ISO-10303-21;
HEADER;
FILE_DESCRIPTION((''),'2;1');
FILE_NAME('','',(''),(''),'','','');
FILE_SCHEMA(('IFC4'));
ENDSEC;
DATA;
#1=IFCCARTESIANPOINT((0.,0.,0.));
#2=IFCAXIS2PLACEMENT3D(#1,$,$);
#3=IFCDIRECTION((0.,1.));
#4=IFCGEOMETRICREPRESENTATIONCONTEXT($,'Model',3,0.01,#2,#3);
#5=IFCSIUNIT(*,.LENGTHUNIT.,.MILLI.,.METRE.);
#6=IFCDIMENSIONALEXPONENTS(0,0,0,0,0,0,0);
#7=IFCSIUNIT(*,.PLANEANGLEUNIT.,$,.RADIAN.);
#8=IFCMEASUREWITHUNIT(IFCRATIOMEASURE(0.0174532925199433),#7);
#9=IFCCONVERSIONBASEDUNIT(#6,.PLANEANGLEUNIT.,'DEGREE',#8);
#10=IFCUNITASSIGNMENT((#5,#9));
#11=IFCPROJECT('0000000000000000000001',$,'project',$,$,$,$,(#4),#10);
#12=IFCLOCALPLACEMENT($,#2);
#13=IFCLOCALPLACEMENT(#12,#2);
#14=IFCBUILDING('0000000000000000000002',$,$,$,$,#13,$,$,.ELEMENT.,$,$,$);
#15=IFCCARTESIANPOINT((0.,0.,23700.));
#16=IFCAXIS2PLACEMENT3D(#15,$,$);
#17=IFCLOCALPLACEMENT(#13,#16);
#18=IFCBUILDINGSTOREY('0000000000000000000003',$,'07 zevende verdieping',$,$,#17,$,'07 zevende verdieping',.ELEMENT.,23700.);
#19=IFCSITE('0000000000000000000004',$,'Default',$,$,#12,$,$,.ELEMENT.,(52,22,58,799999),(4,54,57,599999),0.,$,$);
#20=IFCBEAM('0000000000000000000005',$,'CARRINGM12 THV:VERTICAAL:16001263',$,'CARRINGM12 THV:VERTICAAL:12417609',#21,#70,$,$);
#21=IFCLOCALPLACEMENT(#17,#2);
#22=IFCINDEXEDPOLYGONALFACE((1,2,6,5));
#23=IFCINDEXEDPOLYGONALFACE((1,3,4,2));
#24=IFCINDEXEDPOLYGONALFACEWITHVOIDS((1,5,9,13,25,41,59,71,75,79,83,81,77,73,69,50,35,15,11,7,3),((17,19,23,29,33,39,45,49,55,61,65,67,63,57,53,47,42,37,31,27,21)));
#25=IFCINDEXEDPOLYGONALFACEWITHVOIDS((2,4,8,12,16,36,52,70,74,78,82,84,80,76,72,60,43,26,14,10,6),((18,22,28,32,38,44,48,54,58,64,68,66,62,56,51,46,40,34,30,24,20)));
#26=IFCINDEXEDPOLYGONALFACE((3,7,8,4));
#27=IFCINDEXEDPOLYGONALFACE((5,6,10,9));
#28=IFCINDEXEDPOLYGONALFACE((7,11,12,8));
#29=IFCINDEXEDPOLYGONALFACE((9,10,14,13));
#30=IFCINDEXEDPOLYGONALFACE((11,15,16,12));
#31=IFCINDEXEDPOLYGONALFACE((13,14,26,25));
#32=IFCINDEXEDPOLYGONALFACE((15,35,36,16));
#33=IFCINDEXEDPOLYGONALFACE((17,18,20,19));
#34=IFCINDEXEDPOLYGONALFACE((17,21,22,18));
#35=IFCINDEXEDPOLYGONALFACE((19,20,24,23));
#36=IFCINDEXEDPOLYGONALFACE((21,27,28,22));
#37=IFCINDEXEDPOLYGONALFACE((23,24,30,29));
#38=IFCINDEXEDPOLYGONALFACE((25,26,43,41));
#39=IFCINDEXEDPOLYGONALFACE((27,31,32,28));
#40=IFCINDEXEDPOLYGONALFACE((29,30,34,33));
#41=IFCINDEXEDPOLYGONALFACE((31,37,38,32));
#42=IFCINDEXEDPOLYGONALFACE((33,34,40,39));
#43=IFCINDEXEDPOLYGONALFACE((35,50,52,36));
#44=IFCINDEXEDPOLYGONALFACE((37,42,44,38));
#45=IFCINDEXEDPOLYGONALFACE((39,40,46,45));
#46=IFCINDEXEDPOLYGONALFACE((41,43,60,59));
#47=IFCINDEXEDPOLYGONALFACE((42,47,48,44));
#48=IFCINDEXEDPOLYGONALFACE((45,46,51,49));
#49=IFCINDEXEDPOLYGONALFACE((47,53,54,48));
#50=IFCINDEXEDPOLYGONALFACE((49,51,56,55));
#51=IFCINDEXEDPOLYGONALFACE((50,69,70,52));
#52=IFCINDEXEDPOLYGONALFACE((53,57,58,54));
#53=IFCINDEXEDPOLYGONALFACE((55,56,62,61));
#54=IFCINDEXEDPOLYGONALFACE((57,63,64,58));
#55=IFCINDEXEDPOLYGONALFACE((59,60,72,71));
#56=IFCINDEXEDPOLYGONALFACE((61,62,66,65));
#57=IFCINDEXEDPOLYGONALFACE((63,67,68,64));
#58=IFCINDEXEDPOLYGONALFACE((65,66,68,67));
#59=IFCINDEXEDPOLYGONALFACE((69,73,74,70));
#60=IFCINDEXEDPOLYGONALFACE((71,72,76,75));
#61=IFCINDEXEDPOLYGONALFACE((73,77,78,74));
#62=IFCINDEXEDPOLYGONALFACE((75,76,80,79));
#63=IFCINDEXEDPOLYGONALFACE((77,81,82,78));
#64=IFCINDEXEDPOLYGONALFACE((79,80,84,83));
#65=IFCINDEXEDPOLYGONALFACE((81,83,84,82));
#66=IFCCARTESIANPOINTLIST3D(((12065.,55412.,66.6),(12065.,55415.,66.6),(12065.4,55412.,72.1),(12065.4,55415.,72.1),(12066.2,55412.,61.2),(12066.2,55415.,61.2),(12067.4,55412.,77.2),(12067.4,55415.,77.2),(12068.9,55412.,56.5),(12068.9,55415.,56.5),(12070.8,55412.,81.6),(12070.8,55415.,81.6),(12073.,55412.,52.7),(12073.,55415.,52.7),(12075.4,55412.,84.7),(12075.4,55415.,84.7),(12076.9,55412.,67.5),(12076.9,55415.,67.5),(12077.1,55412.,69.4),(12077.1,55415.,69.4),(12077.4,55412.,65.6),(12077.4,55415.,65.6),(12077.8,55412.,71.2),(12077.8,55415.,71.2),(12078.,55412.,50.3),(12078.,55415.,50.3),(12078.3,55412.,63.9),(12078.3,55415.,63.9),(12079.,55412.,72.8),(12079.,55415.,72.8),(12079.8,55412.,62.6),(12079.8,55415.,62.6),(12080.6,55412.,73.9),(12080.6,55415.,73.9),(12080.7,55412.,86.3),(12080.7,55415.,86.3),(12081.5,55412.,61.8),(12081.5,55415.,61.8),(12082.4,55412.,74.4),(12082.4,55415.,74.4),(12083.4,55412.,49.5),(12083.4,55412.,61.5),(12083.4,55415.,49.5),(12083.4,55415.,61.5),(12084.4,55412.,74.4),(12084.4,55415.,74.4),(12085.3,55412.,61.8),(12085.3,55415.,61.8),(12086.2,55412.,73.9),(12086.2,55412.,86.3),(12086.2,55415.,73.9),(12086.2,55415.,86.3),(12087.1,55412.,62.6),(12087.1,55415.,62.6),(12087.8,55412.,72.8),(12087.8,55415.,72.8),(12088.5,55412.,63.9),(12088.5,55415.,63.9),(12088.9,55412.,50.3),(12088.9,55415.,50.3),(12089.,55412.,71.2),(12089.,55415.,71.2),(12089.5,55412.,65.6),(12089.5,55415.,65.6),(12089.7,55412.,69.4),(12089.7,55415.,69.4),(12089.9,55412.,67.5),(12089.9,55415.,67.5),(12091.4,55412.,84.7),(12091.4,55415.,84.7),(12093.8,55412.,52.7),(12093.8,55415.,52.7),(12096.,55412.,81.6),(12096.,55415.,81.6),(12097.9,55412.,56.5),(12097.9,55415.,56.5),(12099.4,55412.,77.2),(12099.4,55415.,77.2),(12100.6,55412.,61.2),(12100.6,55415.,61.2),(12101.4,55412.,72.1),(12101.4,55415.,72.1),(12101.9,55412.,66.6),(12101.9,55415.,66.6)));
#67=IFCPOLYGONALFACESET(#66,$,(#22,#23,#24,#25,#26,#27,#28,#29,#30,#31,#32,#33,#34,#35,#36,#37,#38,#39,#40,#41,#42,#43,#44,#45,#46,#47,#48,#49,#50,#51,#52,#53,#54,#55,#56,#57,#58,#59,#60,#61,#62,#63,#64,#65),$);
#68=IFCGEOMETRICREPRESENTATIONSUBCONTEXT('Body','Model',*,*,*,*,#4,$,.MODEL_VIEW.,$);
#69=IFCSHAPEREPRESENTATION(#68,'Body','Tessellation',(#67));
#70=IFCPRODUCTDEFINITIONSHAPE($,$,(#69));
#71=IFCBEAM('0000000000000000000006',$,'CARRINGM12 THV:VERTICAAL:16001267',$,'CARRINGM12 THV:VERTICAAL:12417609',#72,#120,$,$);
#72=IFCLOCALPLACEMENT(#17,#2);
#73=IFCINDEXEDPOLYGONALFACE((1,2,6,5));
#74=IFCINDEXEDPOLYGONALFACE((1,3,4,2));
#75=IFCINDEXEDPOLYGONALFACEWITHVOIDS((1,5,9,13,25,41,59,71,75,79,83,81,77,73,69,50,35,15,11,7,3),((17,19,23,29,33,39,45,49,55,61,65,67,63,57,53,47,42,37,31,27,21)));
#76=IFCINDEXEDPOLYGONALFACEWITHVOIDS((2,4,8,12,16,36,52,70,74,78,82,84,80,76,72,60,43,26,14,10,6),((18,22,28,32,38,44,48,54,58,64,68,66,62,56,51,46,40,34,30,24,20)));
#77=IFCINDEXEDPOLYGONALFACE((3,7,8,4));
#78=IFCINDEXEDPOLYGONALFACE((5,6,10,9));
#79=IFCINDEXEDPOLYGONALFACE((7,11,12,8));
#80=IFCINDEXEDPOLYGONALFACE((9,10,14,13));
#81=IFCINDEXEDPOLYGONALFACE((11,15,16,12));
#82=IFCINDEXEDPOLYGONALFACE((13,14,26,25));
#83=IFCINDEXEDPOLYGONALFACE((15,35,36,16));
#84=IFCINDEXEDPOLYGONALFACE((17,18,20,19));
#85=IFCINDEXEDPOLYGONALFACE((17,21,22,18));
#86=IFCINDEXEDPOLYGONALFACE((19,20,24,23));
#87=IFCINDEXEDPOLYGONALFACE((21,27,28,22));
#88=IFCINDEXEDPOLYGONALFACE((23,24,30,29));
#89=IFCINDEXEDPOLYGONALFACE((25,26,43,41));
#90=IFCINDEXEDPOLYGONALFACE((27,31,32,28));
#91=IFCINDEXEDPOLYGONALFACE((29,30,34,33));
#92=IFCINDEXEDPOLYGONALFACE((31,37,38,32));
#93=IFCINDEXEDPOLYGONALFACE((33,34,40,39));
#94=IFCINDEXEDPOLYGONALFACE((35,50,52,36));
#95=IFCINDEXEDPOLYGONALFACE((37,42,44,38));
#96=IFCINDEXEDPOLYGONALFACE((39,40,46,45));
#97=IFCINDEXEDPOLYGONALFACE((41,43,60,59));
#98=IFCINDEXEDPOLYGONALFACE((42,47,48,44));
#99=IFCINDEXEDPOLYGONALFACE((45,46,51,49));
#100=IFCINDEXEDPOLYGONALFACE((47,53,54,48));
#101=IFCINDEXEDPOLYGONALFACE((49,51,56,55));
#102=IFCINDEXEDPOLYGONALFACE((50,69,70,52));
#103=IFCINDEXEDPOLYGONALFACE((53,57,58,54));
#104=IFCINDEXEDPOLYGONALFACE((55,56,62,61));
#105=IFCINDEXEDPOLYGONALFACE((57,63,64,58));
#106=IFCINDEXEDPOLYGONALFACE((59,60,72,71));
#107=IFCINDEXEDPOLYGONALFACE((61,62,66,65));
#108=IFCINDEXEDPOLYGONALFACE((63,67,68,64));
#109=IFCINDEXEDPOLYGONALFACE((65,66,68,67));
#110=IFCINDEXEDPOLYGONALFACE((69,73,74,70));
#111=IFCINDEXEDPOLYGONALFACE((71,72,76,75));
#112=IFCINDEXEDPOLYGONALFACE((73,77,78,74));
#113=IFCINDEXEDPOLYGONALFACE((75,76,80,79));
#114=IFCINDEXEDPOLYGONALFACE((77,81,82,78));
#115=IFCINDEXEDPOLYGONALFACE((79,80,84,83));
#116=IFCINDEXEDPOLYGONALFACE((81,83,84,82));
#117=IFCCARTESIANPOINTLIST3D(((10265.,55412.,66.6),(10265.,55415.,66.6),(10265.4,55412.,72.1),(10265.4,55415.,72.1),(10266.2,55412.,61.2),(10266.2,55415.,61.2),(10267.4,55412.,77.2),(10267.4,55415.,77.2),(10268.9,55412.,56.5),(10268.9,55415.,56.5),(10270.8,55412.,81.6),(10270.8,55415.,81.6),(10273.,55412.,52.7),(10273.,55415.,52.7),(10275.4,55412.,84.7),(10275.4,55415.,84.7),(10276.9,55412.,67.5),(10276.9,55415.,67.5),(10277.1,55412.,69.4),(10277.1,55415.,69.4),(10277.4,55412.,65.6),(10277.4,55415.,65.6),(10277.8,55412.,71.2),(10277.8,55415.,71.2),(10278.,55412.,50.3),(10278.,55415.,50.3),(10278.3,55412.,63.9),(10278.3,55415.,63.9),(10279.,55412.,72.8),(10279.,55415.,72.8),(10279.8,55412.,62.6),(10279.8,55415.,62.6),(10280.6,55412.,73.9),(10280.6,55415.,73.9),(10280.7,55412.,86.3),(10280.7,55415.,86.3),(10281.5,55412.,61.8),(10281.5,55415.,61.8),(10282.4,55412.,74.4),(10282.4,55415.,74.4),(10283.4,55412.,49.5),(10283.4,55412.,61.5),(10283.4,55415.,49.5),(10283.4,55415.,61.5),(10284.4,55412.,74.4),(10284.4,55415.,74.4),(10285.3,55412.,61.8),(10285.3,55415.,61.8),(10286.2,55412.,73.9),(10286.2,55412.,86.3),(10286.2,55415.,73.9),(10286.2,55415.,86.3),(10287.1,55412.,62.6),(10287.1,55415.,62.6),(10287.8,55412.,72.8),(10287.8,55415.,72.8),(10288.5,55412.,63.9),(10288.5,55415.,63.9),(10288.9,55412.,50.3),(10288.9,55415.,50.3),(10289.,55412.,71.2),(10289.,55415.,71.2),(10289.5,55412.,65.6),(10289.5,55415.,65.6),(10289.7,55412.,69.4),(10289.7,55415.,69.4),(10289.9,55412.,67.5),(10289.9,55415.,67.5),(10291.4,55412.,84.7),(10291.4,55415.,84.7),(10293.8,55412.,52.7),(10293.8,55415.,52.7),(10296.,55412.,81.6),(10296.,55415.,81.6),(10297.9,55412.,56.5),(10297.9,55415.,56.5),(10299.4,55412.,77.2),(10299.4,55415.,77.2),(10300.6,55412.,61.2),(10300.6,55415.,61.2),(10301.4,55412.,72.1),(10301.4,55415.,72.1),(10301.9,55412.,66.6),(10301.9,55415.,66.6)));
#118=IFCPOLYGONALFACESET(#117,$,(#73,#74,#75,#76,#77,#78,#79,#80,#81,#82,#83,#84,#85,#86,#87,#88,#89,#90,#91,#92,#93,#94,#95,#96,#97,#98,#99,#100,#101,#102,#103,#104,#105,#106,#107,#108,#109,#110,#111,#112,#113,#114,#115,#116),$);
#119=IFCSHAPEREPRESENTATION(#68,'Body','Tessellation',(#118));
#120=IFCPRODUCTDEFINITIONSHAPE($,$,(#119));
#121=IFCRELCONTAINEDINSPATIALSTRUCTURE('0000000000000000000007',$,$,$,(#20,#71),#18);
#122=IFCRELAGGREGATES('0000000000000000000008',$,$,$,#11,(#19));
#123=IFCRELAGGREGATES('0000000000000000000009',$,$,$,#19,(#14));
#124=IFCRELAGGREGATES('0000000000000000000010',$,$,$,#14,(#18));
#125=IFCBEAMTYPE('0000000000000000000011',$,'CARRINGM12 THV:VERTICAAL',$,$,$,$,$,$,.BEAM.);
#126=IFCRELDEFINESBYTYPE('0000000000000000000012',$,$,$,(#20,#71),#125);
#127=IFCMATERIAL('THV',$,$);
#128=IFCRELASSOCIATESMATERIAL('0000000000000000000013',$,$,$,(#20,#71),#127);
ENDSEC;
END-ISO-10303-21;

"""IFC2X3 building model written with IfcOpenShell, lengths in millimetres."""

from ifc_helpers import new_model, entity, si_unit, converted_unit, direction, frame, origin, origin_2d_with_axis, place, context, subcontext, project, spatial, hollow_circle, extrude, material, type_object, element, save


model = new_model("IFC2X3")

# Units and contexts
model_context = context("Model", 3, precision=0.01, world=origin(), true_north=direction((0.0, 1.0)))
body_context = subcontext(model_context, "Body", "Model", "MODEL_VIEW")
ifc_project = project(units=[si_unit("LENGTHUNIT", "METRE", prefix="MILLI"), converted_unit("PLANEANGLEUNIT", "DEGREE", entity("IfcRatioMeasure", 0.0174532925199433), si_unit("PLANEANGLEUNIT", "RADIAN"), dimensions=[0, 0, 0, 0, 0, 0, 0])], contexts=[model_context])

# Site, building, storey
site_placement = place(None, origin())
site = spatial("IfcSite", under=ifc_project, at=site_placement, Name="Default", CompositionType="ELEMENT", RefLatitude=(52, 22, 58, 799999), RefLongitude=(4, 54, 57, 599999), RefElevation=0.0)
building_placement = place(site_placement, origin())
building = spatial("IfcBuilding", under=site, at=building_placement, CompositionType="ELEMENT")
storey_placement = place(building_placement, frame((0.0, 0.0, 23700.0)))
storey = spatial("IfcBuildingStorey", under=building, at=storey_placement, Name="07 zevende verdieping", LongName="07 zevende verdieping", CompositionType="ELEMENT", Elevation=23700.0)

# Beams
ifc_material = material(Name="THV")
beam_type = type_object("IfcBeamType", Name="CARRINGM12 THV:VERTICAAL", PredefinedType="BEAM")
beam_1_placement = place(storey_placement, origin())
element("IfcBeam", 1, at=beam_1_placement, inside=storey, type_object=beam_type, material=ifc_material, Name="CARRINGM12 THV:VERTICAAL:16001263", ObjectType="CARRINGM12 THV:VERTICAAL:12417609", context=body_context, shape_type="SweptSolid", body=[
    extrude(hollow_circle(Radius=18.5, WallThickness=12.0, at=origin_2d_with_axis()), frame((12083.4, 55412.0, 68.0), z_axis=(0.0, 1.0, 0.0), x_axis=(0.0, 0.0, -1.0)), (0.0, 0.0, 1.0), 3.0),
])
beam_2_placement = place(storey_placement, origin())
element("IfcBeam", 2, at=beam_2_placement, inside=storey, type_object=beam_type, material=ifc_material, Name="CARRINGM12 THV:VERTICAAL:16001267", ObjectType="CARRINGM12 THV:VERTICAAL:12417609", context=body_context, shape_type="SweptSolid", body=[
    extrude(hollow_circle(Radius=18.5, WallThickness=12.0, at=origin_2d_with_axis()), frame((10283.4, 55412.0, 68.0), z_axis=(0.0, 1.0, 0.0), x_axis=(0.0, 0.0, -1.0)), (0.0, 0.0, 1.0), 3.0),
])

save(model, "model.ifc")
